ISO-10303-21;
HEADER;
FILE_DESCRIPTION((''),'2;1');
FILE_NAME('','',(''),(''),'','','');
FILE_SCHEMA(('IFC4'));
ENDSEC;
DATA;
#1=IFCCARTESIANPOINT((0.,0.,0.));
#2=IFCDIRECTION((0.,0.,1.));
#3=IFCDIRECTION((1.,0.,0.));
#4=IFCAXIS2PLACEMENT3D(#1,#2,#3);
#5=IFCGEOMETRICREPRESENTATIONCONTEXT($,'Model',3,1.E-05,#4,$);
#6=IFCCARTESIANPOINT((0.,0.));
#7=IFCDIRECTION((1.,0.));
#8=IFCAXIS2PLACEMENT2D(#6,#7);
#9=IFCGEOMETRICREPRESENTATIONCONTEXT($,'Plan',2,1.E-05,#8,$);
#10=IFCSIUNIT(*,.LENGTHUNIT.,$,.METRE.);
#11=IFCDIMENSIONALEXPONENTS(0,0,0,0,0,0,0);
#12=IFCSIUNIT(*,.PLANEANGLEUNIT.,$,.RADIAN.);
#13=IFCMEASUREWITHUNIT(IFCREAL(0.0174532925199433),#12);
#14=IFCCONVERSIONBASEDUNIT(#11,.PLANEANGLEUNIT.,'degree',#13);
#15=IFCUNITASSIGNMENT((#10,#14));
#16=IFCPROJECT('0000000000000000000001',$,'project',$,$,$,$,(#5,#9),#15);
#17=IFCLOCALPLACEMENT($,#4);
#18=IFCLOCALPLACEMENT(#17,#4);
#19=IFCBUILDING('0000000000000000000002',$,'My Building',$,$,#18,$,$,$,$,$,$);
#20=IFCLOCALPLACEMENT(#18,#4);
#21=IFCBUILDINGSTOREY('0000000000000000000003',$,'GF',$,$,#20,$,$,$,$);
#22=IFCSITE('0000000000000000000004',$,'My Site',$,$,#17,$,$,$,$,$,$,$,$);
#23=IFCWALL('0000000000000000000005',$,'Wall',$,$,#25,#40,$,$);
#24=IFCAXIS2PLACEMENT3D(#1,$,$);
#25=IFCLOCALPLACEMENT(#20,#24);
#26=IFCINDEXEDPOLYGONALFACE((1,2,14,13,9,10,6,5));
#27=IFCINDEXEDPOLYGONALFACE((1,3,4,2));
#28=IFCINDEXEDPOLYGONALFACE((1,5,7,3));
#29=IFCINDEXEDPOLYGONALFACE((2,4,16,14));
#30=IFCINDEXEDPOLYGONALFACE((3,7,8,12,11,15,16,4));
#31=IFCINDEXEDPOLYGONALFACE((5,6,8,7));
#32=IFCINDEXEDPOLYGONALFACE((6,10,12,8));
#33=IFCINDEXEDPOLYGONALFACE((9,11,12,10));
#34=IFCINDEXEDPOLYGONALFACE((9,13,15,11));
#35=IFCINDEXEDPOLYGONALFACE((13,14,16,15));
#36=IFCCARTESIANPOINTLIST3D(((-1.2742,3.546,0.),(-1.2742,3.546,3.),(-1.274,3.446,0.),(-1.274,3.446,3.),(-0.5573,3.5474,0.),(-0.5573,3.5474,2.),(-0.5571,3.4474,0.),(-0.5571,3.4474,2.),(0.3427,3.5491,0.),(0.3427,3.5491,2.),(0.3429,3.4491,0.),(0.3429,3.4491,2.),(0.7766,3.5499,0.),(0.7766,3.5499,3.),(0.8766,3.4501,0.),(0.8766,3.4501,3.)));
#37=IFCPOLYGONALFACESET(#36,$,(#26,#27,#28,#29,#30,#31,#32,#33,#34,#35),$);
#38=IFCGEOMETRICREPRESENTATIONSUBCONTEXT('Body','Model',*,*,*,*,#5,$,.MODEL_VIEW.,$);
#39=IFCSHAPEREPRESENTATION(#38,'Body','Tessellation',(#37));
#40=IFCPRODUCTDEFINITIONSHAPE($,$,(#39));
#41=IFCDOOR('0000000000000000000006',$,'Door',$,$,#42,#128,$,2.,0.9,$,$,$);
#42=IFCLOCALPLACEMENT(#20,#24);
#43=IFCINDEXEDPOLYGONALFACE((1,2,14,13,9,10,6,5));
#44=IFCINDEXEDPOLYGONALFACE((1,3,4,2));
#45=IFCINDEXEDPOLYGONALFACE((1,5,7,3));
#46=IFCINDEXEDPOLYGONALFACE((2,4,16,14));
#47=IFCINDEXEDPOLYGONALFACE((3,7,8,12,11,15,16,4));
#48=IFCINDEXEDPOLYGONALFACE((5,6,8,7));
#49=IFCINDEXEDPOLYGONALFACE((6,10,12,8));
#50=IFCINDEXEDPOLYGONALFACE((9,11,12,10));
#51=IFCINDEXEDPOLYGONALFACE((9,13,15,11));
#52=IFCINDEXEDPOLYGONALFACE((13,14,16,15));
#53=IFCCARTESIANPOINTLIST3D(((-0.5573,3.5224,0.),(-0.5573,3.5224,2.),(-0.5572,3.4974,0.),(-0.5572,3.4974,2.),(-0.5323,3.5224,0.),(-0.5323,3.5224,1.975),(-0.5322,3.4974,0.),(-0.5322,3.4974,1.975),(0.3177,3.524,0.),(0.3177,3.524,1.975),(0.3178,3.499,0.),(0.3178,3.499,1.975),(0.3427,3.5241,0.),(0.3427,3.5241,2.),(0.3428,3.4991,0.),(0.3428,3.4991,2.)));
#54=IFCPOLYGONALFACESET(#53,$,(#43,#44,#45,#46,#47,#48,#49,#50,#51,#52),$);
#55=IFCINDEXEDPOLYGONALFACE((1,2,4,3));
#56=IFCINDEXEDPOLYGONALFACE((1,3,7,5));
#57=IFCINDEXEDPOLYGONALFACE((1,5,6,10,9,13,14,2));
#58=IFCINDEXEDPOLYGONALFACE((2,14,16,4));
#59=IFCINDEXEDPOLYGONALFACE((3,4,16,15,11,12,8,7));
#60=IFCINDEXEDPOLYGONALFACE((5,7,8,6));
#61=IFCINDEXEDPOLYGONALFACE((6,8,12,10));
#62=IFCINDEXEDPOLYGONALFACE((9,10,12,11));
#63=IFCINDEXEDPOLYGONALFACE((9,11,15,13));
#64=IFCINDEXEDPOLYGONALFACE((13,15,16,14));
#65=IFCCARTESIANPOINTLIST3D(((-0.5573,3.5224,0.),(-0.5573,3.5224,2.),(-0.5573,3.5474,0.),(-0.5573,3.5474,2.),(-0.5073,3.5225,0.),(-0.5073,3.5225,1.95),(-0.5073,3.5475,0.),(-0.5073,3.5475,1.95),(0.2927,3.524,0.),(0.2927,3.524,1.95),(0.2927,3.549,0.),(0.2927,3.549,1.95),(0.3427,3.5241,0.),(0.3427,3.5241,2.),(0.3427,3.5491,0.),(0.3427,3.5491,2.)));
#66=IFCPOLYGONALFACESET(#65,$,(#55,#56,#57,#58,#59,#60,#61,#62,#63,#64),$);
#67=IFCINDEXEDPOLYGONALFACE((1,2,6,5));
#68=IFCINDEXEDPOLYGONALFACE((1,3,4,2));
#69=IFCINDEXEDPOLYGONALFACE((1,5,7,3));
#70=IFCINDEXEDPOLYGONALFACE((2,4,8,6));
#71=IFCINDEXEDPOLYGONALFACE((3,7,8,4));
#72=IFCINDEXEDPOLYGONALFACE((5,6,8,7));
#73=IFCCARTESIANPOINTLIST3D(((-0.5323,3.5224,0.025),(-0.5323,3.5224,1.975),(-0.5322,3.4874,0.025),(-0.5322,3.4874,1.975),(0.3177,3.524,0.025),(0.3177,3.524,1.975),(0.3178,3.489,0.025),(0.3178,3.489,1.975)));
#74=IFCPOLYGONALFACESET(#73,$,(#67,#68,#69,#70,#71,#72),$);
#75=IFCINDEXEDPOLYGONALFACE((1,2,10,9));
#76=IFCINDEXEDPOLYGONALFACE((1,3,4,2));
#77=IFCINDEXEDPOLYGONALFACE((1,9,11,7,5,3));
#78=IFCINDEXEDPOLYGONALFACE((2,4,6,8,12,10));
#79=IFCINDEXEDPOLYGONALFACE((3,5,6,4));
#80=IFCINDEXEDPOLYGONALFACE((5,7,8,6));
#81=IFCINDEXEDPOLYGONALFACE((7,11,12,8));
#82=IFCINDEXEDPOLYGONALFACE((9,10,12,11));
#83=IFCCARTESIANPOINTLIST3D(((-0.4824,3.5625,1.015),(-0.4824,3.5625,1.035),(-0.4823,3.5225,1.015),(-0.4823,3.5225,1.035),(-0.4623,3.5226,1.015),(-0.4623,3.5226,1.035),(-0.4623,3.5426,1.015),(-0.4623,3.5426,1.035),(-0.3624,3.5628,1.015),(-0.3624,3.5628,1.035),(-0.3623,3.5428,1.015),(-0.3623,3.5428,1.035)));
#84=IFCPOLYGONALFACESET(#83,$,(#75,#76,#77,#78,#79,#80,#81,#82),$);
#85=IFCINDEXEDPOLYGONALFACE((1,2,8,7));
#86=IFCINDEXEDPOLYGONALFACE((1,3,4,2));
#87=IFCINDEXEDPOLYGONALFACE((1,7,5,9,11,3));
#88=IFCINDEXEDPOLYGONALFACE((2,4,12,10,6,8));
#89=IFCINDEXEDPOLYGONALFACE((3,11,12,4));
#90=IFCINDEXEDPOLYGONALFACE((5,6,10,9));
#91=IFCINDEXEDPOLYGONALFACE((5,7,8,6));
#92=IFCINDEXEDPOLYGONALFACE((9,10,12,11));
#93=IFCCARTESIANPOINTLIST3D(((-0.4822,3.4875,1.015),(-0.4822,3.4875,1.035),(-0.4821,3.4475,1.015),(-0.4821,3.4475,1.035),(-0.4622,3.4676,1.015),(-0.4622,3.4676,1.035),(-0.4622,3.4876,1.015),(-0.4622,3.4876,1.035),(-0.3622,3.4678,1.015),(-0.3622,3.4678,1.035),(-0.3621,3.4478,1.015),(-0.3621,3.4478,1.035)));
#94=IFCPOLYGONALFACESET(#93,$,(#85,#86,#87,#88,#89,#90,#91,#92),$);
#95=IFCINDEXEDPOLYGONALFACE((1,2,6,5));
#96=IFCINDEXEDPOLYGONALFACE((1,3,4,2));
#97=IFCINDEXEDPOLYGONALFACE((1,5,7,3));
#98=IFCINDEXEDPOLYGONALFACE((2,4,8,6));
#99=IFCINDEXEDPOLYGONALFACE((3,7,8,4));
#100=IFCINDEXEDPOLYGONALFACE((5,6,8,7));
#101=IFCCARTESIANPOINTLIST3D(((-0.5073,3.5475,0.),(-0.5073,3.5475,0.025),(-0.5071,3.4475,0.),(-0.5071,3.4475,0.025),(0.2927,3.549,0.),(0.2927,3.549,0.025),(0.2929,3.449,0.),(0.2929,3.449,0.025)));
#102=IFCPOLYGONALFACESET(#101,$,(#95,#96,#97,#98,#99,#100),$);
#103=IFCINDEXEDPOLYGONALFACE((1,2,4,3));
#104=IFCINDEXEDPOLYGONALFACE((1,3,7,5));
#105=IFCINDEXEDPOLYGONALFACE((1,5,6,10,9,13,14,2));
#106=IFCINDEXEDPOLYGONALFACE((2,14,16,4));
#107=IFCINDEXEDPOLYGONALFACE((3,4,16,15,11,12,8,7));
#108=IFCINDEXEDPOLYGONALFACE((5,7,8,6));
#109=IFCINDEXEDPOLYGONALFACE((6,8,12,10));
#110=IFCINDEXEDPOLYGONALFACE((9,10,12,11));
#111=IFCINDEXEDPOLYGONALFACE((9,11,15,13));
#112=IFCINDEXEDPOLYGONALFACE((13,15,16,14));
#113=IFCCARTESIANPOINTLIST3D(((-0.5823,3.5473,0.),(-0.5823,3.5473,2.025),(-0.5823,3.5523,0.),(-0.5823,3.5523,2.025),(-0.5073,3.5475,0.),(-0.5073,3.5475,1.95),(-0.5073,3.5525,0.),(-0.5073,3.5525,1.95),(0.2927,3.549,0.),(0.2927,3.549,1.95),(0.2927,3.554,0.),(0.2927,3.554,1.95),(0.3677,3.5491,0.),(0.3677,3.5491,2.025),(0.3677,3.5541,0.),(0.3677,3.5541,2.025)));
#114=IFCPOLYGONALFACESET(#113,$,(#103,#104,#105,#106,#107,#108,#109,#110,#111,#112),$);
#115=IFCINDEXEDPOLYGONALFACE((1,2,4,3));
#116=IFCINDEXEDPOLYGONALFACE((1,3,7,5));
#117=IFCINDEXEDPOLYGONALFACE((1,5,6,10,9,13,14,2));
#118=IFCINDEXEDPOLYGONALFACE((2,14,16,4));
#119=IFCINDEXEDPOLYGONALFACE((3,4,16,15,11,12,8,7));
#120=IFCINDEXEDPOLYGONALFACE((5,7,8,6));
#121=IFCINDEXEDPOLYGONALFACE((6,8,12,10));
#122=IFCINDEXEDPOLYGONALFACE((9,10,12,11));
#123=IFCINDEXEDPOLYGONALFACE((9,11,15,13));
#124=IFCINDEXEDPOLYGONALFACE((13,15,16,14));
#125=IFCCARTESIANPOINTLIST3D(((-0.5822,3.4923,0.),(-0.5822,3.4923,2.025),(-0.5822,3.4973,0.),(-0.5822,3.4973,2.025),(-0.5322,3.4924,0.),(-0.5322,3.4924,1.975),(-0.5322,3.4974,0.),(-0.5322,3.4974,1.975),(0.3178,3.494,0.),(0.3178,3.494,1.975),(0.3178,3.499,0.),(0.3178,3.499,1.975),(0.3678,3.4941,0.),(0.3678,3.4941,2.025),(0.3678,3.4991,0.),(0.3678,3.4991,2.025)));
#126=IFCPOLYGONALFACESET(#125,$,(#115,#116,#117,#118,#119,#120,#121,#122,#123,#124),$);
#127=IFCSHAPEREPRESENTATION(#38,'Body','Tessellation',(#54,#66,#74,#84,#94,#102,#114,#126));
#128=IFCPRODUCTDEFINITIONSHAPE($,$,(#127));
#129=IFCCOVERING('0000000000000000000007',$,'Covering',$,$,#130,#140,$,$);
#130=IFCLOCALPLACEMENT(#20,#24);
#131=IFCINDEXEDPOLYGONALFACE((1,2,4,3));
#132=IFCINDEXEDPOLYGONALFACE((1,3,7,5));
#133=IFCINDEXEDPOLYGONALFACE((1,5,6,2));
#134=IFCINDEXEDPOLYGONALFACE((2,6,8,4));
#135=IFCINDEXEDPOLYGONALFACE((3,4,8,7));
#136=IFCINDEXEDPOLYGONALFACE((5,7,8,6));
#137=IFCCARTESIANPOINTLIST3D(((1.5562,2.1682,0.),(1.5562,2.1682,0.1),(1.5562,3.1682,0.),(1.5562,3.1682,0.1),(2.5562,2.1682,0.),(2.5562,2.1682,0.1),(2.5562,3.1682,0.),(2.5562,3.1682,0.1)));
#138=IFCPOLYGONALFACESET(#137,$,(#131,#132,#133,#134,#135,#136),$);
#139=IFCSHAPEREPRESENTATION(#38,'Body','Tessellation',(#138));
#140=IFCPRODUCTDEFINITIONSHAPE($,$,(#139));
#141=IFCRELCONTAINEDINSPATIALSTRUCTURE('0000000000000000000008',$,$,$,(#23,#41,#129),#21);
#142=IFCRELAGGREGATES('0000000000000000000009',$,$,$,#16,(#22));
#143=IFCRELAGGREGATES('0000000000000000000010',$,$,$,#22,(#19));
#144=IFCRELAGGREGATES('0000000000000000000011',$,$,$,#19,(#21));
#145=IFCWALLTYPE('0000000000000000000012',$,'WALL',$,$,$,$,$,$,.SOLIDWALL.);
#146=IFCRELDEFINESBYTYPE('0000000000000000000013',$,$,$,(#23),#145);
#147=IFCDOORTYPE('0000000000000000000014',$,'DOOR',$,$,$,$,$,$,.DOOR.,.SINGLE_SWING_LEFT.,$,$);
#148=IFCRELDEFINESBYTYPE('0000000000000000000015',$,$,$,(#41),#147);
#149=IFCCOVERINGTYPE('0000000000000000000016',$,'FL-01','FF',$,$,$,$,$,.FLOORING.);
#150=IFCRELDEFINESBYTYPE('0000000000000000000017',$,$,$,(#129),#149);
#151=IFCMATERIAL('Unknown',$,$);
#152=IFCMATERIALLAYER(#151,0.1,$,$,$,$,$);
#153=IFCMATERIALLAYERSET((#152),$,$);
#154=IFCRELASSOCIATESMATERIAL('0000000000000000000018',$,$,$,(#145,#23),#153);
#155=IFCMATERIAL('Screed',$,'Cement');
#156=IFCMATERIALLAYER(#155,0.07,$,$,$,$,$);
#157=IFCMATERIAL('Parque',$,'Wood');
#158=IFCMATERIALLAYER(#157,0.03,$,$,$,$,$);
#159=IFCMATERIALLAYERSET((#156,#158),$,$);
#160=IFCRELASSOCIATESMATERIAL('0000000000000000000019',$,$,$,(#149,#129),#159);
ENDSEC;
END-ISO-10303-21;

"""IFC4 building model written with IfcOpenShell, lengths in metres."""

from ifc_helpers import new_model, entity, si_unit, converted_unit, frame, origin_with_axes, origin_2d_with_axis, place, context, subcontext, project, spatial, line, indexed_curve, outline, extrude, shape, source, transform, mapped, material, layer, layer_set, layer_usage, type_object, type_shapes, element, fill, save


model = new_model("IFC4")

# Units and contexts
model_context = context("Model", 3, precision=1e-05, world=origin_with_axes())
plan_context = context("Plan", 2, precision=1e-05, world=origin_2d_with_axis())
body_context_1 = subcontext(model_context, "Body", "Model", "MODEL_VIEW")
body_context_2 = subcontext(plan_context, "Body", "Plan", "PLAN_VIEW")
ifc_project = project(units=[si_unit("LENGTHUNIT", "METRE"), converted_unit("PLANEANGLEUNIT", "degree", entity("IfcReal", 0.0174532925199433), si_unit("PLANEANGLEUNIT", "RADIAN"), dimensions=[0, 0, 0, 0, 0, 0, 0])], contexts=[model_context, plan_context])

# Site, building, storey
site_placement = place(None, origin_with_axes())
site = spatial("IfcSite", under=ifc_project, at=site_placement, Name="My Site")
building_placement = place(site_placement, origin_with_axes())
building = spatial("IfcBuilding", under=site, at=building_placement, Name="My Building")
storey_placement = place(building_placement, origin_with_axes())
storey = spatial("IfcBuildingStorey", under=building, at=storey_placement, Name="GF")

# Shared definitions
ifc_material_1 = material(Name="Unknown")

# Shared definitions
ifc_layer_1 = layer(ifc_material_1, 0.1)
ifc_layer_set_1 = layer_set([ifc_layer_1])
wall_type = type_object("IfcWallType", Name="WALL", PredefinedType="SOLIDWALL", material=ifc_layer_set_1)
shared_shape_1 = source(origin_with_axes(), body_context_1, "Body", "SweptSolid", [
    extrude(outline(indexed_curve([(0.0, 0.0), (0.9, 0.0), (0.9, 2.0), (0.0, 2.0)], segments=[line(1, 2, 3, 4, 1)])), frame((0.0, -0.6, 0.0), z_axis=(0.0, -1.0, 0.0), x_axis=(1.0, 0.0, 0.0)), (0.0, 0.0, -1.0), 1.2),
])
door_type = type_object("IfcDoorType", Name="DOOR", OperationType="SINGLE_SWING_LEFT", PredefinedType="DOOR")
shared_shape_2 = source(origin_with_axes(), body_context_1, "Body", "SweptSolid", [
    extrude(outline(indexed_curve([(0.0, 0.0), (0.0, 2.0), (0.9, 2.0), (0.9, 0.0), (0.875, 0.0), (0.875, 1.975), (0.025, 1.975), (0.025, 0.0)], segments=[line(1, 2, 3, 4, 5, 6, 7, 8, 1)])), frame((0.0, 0.025, 0.0), z_axis=(0.0, -1.0, 0.0), x_axis=(1.0, 0.0, 0.0)), (0.0, 0.0, -1.0), 0.025),
    extrude(outline(indexed_curve([(0.0, 0.0), (0.0, 2.0), (0.9, 2.0), (0.9, 0.0), (0.85, 0.0), (0.85, 1.95), (0.05, 1.95), (0.05, 0.0)], segments=[line(1, 2, 3, 4, 5, 6, 7, 8, 1)])), frame((0.0, 0.0, 0.0), z_axis=(0.0, -1.0, 0.0), x_axis=(1.0, 0.0, 0.0)), (0.0, 0.0, -1.0), 0.025),
    extrude(outline(indexed_curve([(0.0, 0.0), (0.85, 0.0), (0.85, 0.035), (0.0, 0.035)], segments=[line(1, 2, 3, 4, 1)])), frame((0.025, 0.025, 0.025), z_axis=(0.0, 0.0, 1.0), x_axis=(1.0, 0.0, 0.0)), (0.0, 0.0, 1.0), 1.95),
    extrude(outline(indexed_curve([(0.0, 0.0), (0.0, -0.04), (-0.12, -0.04), (-0.12, -0.02), (-0.02, -0.02), (-0.02, 0.0)], segments=[line(1, 2, 3, 4, 5, 6, 1)])), frame((0.825, 0.025, 1.015), z_axis=(0.0, 0.0, 1.0), x_axis=(1.0, 0.0, 0.0)), (0.0, 0.0, 1.0), 0.02),
    extrude(outline(indexed_curve([(0.0, 0.0), (0.0, 0.04), (-0.12, 0.04), (-0.12, 0.02), (-0.02, 0.02), (-0.02, 0.0)], segments=[line(1, 2, 3, 4, 5, 6, 1)])), frame((0.825, 0.06, 1.015), z_axis=(0.0, 0.0, 1.0), x_axis=(1.0, 0.0, 0.0)), (0.0, 0.0, 1.0), 0.02),
    extrude(outline(indexed_curve([(0.0, 0.0), (0.8, 0.0), (0.8, 0.1), (0.0, 0.1)], segments=[line(1, 2, 3, 4, 1)])), frame((0.05, 0.0, 0.0), z_axis=(0.0, 0.0, 1.0), x_axis=(1.0, 0.0, 0.0)), (0.0, 0.0, 1.0), 0.025),
    extrude(outline(indexed_curve([(0.0, 0.0), (0.0, 2.025), (0.95, 2.025), (0.95, 0.0), (0.875, 0.0), (0.875, 1.95), (0.075, 1.95), (0.075, 0.0)], segments=[line(1, 2, 3, 4, 5, 6, 7, 8, 1)])), frame((-0.025, -0.005, 0.0), z_axis=(0.0, -1.0, 0.0), x_axis=(1.0, 0.0, 0.0)), (0.0, 0.0, -1.0), 0.005),
    extrude(outline(indexed_curve([(0.0, 0.0), (0.0, 2.025), (0.95, 2.025), (0.95, 0.0), (0.9, 0.0), (0.9, 1.975), (0.05, 1.975), (0.05, 0.0)], segments=[line(1, 2, 3, 4, 5, 6, 7, 8, 1)])), frame((-0.025, 0.05, 0.0), z_axis=(0.0, -1.0, 0.0), x_axis=(1.0, 0.0, 0.0)), (0.0, 0.0, -1.0), 0.005),
])
shared_shape_3 = source(origin_with_axes(), body_context_2, "Body", "Curve2D", [
    entity("IfcIndexedPolyCurve", entity("IfcCartesianPointList2D", [[0.0, 0.0], [0.0, 0.05], [0.025, 0.05], [0.025, 0.025], [0.05, 0.025], [0.05, 0.0]]), [entity("IfcLineIndex", [1, 2, 3, 4, 5, 6, 1])]),
    entity("IfcIndexedPolyCurve", entity("IfcCartesianPointList2D", [[0.9, 0.0], [0.9, 0.05], [0.875, 0.05], [0.875, 0.025], [0.85, 0.025], [0.85, 0.0]]), [entity("IfcLineIndex", [1, 2, 3, 4, 5, 6, 1])]),
    entity("IfcTrimmedCurve", entity("IfcEllipse", entity("IfcAxis2Placement2D", entity("IfcCartesianPoint", [0.06, 0.05]), entity("IfcDirection", [1.0, 0.0])), 0.815, 0.85), [entity("IfcCartesianPoint", [0.875, 0.05])], [entity("IfcCartesianPoint", [0.06, 0.9])], True, "CARTESIAN"),
    entity("IfcIndexedPolyCurve", entity("IfcCartesianPointList2D", [[0.025, 0.05], [0.06, 0.05], [0.06, 0.9], [0.025, 0.9]]), [entity("IfcLineIndex", [1, 2, 3, 4, 1])]),
])
type_shapes(door_type, [shared_shape_2, shared_shape_3])

# Wall, opening, door
ifc_layer_usage_1 = layer_usage(ifc_layer_set_1, "AXIS2", "POSITIVE", 0.0)
wall_1_placement = place(storey_placement, frame((0.7766, 3.5499, 0.0), z_axis=(0.0, 0.0, 1.0), x_axis=(-0.999998, -0.001879, 0.0)))
wall_1 = element("IfcWall", 1, at=wall_1_placement, inside=storey, type_object=wall_type, material=ifc_layer_usage_1, Name="Wall", context=body_context_1, shape_type="SweptSolid", body=[
    extrude(outline(indexed_curve([(0.0, 0.0), (-0.0998, 0.1), (2.0508, 0.1), (2.0508, 0.0)], segments=[line(1, 2, 3, 4, 1)])), origin_with_axes(), (0.0, 0.0, 1.0), 3.0),
])
opening_1_placement = place(wall_1_placement, frame((0.4339, 0.0, 0.0), z_axis=(0.0, 0.0, 1.0), x_axis=(1.0, 0.0, 0.0)))
opening_1 = element("IfcOpeningElement", 2, at=opening_1_placement, cuts=wall_1, PredefinedType="OPENING", context=body_context_1, shape_type="MappedRepresentation", body=[
    mapped(shared_shape_1, transform((0.0, 0.0, 0.0), x_axis=(1.0, 0.0, 0.0), y_axis=(0.0, 1.0, 0.0), z_axis=(0.0, 0.0, 1.0), scale=1.0)),
])
door_1_placement = place(opening_1_placement, frame((0.0, 0.0, 0.0), z_axis=(0.0, 0.0, 1.0), x_axis=(1.0, 0.0, 0.0)))
door_1 = element("IfcDoor", 3, at=door_1_placement, inside=storey, type_object=door_type, Name="Door", OverallHeight=2.0, OverallWidth=0.9, shapes=[
    shape(body_context_1, "Body", "MappedRepresentation", [mapped(shared_shape_2, transform((0.0, 0.0, 0.0), x_axis=(1.0, 0.0, 0.0), y_axis=(0.0, 1.0, 0.0), z_axis=(0.0, 0.0, 1.0), scale=1.0))]),
    shape(body_context_2, "Body", "MappedRepresentation", [mapped(shared_shape_3, transform((0.0, 0.0, 0.0), x_axis=(1.0, 0.0, 0.0), y_axis=(0.0, 1.0, 0.0), z_axis=(0.0, 0.0, 1.0), scale=1.0))]),
])
fill(opening_1, door_1)

# Covering
ifc_material_2 = material(Name="Screed", Category="Cement")
ifc_layer_2 = layer(ifc_material_2, 0.07)
ifc_material_3 = material(Name="Parque", Category="Wood")
ifc_layer_3 = layer(ifc_material_3, 0.03)
ifc_layer_set_2 = layer_set([ifc_layer_2, ifc_layer_3])
ifc_layer_usage_2 = layer_usage(ifc_layer_set_2, "AXIS3", "POSITIVE", 0.0)
covering_type = type_object("IfcCoveringType", Name="FL-01", Description="FF", PredefinedType="FLOORING", material=ifc_layer_set_2)
covering_placement = place(storey_placement, frame((1.5562, 2.1682, 0.0), z_axis=(0.0, 0.0, 1.0), x_axis=(1.0, 0.0, 0.0)))
element("IfcCovering", 4, at=covering_placement, inside=storey, type_object=covering_type, material=ifc_layer_usage_2, Name="Covering", context=body_context_1, shape_type="SweptSolid", body=[
    extrude(outline(indexed_curve([(0.0, 0.0), (1.0, 0.0), (1.0, 1.0), (0.0, 1.0), (0.0, 0.0)])), None, (0.0, 0.0, 1.0), 0.1),
])

save(model, "model.ifc")
